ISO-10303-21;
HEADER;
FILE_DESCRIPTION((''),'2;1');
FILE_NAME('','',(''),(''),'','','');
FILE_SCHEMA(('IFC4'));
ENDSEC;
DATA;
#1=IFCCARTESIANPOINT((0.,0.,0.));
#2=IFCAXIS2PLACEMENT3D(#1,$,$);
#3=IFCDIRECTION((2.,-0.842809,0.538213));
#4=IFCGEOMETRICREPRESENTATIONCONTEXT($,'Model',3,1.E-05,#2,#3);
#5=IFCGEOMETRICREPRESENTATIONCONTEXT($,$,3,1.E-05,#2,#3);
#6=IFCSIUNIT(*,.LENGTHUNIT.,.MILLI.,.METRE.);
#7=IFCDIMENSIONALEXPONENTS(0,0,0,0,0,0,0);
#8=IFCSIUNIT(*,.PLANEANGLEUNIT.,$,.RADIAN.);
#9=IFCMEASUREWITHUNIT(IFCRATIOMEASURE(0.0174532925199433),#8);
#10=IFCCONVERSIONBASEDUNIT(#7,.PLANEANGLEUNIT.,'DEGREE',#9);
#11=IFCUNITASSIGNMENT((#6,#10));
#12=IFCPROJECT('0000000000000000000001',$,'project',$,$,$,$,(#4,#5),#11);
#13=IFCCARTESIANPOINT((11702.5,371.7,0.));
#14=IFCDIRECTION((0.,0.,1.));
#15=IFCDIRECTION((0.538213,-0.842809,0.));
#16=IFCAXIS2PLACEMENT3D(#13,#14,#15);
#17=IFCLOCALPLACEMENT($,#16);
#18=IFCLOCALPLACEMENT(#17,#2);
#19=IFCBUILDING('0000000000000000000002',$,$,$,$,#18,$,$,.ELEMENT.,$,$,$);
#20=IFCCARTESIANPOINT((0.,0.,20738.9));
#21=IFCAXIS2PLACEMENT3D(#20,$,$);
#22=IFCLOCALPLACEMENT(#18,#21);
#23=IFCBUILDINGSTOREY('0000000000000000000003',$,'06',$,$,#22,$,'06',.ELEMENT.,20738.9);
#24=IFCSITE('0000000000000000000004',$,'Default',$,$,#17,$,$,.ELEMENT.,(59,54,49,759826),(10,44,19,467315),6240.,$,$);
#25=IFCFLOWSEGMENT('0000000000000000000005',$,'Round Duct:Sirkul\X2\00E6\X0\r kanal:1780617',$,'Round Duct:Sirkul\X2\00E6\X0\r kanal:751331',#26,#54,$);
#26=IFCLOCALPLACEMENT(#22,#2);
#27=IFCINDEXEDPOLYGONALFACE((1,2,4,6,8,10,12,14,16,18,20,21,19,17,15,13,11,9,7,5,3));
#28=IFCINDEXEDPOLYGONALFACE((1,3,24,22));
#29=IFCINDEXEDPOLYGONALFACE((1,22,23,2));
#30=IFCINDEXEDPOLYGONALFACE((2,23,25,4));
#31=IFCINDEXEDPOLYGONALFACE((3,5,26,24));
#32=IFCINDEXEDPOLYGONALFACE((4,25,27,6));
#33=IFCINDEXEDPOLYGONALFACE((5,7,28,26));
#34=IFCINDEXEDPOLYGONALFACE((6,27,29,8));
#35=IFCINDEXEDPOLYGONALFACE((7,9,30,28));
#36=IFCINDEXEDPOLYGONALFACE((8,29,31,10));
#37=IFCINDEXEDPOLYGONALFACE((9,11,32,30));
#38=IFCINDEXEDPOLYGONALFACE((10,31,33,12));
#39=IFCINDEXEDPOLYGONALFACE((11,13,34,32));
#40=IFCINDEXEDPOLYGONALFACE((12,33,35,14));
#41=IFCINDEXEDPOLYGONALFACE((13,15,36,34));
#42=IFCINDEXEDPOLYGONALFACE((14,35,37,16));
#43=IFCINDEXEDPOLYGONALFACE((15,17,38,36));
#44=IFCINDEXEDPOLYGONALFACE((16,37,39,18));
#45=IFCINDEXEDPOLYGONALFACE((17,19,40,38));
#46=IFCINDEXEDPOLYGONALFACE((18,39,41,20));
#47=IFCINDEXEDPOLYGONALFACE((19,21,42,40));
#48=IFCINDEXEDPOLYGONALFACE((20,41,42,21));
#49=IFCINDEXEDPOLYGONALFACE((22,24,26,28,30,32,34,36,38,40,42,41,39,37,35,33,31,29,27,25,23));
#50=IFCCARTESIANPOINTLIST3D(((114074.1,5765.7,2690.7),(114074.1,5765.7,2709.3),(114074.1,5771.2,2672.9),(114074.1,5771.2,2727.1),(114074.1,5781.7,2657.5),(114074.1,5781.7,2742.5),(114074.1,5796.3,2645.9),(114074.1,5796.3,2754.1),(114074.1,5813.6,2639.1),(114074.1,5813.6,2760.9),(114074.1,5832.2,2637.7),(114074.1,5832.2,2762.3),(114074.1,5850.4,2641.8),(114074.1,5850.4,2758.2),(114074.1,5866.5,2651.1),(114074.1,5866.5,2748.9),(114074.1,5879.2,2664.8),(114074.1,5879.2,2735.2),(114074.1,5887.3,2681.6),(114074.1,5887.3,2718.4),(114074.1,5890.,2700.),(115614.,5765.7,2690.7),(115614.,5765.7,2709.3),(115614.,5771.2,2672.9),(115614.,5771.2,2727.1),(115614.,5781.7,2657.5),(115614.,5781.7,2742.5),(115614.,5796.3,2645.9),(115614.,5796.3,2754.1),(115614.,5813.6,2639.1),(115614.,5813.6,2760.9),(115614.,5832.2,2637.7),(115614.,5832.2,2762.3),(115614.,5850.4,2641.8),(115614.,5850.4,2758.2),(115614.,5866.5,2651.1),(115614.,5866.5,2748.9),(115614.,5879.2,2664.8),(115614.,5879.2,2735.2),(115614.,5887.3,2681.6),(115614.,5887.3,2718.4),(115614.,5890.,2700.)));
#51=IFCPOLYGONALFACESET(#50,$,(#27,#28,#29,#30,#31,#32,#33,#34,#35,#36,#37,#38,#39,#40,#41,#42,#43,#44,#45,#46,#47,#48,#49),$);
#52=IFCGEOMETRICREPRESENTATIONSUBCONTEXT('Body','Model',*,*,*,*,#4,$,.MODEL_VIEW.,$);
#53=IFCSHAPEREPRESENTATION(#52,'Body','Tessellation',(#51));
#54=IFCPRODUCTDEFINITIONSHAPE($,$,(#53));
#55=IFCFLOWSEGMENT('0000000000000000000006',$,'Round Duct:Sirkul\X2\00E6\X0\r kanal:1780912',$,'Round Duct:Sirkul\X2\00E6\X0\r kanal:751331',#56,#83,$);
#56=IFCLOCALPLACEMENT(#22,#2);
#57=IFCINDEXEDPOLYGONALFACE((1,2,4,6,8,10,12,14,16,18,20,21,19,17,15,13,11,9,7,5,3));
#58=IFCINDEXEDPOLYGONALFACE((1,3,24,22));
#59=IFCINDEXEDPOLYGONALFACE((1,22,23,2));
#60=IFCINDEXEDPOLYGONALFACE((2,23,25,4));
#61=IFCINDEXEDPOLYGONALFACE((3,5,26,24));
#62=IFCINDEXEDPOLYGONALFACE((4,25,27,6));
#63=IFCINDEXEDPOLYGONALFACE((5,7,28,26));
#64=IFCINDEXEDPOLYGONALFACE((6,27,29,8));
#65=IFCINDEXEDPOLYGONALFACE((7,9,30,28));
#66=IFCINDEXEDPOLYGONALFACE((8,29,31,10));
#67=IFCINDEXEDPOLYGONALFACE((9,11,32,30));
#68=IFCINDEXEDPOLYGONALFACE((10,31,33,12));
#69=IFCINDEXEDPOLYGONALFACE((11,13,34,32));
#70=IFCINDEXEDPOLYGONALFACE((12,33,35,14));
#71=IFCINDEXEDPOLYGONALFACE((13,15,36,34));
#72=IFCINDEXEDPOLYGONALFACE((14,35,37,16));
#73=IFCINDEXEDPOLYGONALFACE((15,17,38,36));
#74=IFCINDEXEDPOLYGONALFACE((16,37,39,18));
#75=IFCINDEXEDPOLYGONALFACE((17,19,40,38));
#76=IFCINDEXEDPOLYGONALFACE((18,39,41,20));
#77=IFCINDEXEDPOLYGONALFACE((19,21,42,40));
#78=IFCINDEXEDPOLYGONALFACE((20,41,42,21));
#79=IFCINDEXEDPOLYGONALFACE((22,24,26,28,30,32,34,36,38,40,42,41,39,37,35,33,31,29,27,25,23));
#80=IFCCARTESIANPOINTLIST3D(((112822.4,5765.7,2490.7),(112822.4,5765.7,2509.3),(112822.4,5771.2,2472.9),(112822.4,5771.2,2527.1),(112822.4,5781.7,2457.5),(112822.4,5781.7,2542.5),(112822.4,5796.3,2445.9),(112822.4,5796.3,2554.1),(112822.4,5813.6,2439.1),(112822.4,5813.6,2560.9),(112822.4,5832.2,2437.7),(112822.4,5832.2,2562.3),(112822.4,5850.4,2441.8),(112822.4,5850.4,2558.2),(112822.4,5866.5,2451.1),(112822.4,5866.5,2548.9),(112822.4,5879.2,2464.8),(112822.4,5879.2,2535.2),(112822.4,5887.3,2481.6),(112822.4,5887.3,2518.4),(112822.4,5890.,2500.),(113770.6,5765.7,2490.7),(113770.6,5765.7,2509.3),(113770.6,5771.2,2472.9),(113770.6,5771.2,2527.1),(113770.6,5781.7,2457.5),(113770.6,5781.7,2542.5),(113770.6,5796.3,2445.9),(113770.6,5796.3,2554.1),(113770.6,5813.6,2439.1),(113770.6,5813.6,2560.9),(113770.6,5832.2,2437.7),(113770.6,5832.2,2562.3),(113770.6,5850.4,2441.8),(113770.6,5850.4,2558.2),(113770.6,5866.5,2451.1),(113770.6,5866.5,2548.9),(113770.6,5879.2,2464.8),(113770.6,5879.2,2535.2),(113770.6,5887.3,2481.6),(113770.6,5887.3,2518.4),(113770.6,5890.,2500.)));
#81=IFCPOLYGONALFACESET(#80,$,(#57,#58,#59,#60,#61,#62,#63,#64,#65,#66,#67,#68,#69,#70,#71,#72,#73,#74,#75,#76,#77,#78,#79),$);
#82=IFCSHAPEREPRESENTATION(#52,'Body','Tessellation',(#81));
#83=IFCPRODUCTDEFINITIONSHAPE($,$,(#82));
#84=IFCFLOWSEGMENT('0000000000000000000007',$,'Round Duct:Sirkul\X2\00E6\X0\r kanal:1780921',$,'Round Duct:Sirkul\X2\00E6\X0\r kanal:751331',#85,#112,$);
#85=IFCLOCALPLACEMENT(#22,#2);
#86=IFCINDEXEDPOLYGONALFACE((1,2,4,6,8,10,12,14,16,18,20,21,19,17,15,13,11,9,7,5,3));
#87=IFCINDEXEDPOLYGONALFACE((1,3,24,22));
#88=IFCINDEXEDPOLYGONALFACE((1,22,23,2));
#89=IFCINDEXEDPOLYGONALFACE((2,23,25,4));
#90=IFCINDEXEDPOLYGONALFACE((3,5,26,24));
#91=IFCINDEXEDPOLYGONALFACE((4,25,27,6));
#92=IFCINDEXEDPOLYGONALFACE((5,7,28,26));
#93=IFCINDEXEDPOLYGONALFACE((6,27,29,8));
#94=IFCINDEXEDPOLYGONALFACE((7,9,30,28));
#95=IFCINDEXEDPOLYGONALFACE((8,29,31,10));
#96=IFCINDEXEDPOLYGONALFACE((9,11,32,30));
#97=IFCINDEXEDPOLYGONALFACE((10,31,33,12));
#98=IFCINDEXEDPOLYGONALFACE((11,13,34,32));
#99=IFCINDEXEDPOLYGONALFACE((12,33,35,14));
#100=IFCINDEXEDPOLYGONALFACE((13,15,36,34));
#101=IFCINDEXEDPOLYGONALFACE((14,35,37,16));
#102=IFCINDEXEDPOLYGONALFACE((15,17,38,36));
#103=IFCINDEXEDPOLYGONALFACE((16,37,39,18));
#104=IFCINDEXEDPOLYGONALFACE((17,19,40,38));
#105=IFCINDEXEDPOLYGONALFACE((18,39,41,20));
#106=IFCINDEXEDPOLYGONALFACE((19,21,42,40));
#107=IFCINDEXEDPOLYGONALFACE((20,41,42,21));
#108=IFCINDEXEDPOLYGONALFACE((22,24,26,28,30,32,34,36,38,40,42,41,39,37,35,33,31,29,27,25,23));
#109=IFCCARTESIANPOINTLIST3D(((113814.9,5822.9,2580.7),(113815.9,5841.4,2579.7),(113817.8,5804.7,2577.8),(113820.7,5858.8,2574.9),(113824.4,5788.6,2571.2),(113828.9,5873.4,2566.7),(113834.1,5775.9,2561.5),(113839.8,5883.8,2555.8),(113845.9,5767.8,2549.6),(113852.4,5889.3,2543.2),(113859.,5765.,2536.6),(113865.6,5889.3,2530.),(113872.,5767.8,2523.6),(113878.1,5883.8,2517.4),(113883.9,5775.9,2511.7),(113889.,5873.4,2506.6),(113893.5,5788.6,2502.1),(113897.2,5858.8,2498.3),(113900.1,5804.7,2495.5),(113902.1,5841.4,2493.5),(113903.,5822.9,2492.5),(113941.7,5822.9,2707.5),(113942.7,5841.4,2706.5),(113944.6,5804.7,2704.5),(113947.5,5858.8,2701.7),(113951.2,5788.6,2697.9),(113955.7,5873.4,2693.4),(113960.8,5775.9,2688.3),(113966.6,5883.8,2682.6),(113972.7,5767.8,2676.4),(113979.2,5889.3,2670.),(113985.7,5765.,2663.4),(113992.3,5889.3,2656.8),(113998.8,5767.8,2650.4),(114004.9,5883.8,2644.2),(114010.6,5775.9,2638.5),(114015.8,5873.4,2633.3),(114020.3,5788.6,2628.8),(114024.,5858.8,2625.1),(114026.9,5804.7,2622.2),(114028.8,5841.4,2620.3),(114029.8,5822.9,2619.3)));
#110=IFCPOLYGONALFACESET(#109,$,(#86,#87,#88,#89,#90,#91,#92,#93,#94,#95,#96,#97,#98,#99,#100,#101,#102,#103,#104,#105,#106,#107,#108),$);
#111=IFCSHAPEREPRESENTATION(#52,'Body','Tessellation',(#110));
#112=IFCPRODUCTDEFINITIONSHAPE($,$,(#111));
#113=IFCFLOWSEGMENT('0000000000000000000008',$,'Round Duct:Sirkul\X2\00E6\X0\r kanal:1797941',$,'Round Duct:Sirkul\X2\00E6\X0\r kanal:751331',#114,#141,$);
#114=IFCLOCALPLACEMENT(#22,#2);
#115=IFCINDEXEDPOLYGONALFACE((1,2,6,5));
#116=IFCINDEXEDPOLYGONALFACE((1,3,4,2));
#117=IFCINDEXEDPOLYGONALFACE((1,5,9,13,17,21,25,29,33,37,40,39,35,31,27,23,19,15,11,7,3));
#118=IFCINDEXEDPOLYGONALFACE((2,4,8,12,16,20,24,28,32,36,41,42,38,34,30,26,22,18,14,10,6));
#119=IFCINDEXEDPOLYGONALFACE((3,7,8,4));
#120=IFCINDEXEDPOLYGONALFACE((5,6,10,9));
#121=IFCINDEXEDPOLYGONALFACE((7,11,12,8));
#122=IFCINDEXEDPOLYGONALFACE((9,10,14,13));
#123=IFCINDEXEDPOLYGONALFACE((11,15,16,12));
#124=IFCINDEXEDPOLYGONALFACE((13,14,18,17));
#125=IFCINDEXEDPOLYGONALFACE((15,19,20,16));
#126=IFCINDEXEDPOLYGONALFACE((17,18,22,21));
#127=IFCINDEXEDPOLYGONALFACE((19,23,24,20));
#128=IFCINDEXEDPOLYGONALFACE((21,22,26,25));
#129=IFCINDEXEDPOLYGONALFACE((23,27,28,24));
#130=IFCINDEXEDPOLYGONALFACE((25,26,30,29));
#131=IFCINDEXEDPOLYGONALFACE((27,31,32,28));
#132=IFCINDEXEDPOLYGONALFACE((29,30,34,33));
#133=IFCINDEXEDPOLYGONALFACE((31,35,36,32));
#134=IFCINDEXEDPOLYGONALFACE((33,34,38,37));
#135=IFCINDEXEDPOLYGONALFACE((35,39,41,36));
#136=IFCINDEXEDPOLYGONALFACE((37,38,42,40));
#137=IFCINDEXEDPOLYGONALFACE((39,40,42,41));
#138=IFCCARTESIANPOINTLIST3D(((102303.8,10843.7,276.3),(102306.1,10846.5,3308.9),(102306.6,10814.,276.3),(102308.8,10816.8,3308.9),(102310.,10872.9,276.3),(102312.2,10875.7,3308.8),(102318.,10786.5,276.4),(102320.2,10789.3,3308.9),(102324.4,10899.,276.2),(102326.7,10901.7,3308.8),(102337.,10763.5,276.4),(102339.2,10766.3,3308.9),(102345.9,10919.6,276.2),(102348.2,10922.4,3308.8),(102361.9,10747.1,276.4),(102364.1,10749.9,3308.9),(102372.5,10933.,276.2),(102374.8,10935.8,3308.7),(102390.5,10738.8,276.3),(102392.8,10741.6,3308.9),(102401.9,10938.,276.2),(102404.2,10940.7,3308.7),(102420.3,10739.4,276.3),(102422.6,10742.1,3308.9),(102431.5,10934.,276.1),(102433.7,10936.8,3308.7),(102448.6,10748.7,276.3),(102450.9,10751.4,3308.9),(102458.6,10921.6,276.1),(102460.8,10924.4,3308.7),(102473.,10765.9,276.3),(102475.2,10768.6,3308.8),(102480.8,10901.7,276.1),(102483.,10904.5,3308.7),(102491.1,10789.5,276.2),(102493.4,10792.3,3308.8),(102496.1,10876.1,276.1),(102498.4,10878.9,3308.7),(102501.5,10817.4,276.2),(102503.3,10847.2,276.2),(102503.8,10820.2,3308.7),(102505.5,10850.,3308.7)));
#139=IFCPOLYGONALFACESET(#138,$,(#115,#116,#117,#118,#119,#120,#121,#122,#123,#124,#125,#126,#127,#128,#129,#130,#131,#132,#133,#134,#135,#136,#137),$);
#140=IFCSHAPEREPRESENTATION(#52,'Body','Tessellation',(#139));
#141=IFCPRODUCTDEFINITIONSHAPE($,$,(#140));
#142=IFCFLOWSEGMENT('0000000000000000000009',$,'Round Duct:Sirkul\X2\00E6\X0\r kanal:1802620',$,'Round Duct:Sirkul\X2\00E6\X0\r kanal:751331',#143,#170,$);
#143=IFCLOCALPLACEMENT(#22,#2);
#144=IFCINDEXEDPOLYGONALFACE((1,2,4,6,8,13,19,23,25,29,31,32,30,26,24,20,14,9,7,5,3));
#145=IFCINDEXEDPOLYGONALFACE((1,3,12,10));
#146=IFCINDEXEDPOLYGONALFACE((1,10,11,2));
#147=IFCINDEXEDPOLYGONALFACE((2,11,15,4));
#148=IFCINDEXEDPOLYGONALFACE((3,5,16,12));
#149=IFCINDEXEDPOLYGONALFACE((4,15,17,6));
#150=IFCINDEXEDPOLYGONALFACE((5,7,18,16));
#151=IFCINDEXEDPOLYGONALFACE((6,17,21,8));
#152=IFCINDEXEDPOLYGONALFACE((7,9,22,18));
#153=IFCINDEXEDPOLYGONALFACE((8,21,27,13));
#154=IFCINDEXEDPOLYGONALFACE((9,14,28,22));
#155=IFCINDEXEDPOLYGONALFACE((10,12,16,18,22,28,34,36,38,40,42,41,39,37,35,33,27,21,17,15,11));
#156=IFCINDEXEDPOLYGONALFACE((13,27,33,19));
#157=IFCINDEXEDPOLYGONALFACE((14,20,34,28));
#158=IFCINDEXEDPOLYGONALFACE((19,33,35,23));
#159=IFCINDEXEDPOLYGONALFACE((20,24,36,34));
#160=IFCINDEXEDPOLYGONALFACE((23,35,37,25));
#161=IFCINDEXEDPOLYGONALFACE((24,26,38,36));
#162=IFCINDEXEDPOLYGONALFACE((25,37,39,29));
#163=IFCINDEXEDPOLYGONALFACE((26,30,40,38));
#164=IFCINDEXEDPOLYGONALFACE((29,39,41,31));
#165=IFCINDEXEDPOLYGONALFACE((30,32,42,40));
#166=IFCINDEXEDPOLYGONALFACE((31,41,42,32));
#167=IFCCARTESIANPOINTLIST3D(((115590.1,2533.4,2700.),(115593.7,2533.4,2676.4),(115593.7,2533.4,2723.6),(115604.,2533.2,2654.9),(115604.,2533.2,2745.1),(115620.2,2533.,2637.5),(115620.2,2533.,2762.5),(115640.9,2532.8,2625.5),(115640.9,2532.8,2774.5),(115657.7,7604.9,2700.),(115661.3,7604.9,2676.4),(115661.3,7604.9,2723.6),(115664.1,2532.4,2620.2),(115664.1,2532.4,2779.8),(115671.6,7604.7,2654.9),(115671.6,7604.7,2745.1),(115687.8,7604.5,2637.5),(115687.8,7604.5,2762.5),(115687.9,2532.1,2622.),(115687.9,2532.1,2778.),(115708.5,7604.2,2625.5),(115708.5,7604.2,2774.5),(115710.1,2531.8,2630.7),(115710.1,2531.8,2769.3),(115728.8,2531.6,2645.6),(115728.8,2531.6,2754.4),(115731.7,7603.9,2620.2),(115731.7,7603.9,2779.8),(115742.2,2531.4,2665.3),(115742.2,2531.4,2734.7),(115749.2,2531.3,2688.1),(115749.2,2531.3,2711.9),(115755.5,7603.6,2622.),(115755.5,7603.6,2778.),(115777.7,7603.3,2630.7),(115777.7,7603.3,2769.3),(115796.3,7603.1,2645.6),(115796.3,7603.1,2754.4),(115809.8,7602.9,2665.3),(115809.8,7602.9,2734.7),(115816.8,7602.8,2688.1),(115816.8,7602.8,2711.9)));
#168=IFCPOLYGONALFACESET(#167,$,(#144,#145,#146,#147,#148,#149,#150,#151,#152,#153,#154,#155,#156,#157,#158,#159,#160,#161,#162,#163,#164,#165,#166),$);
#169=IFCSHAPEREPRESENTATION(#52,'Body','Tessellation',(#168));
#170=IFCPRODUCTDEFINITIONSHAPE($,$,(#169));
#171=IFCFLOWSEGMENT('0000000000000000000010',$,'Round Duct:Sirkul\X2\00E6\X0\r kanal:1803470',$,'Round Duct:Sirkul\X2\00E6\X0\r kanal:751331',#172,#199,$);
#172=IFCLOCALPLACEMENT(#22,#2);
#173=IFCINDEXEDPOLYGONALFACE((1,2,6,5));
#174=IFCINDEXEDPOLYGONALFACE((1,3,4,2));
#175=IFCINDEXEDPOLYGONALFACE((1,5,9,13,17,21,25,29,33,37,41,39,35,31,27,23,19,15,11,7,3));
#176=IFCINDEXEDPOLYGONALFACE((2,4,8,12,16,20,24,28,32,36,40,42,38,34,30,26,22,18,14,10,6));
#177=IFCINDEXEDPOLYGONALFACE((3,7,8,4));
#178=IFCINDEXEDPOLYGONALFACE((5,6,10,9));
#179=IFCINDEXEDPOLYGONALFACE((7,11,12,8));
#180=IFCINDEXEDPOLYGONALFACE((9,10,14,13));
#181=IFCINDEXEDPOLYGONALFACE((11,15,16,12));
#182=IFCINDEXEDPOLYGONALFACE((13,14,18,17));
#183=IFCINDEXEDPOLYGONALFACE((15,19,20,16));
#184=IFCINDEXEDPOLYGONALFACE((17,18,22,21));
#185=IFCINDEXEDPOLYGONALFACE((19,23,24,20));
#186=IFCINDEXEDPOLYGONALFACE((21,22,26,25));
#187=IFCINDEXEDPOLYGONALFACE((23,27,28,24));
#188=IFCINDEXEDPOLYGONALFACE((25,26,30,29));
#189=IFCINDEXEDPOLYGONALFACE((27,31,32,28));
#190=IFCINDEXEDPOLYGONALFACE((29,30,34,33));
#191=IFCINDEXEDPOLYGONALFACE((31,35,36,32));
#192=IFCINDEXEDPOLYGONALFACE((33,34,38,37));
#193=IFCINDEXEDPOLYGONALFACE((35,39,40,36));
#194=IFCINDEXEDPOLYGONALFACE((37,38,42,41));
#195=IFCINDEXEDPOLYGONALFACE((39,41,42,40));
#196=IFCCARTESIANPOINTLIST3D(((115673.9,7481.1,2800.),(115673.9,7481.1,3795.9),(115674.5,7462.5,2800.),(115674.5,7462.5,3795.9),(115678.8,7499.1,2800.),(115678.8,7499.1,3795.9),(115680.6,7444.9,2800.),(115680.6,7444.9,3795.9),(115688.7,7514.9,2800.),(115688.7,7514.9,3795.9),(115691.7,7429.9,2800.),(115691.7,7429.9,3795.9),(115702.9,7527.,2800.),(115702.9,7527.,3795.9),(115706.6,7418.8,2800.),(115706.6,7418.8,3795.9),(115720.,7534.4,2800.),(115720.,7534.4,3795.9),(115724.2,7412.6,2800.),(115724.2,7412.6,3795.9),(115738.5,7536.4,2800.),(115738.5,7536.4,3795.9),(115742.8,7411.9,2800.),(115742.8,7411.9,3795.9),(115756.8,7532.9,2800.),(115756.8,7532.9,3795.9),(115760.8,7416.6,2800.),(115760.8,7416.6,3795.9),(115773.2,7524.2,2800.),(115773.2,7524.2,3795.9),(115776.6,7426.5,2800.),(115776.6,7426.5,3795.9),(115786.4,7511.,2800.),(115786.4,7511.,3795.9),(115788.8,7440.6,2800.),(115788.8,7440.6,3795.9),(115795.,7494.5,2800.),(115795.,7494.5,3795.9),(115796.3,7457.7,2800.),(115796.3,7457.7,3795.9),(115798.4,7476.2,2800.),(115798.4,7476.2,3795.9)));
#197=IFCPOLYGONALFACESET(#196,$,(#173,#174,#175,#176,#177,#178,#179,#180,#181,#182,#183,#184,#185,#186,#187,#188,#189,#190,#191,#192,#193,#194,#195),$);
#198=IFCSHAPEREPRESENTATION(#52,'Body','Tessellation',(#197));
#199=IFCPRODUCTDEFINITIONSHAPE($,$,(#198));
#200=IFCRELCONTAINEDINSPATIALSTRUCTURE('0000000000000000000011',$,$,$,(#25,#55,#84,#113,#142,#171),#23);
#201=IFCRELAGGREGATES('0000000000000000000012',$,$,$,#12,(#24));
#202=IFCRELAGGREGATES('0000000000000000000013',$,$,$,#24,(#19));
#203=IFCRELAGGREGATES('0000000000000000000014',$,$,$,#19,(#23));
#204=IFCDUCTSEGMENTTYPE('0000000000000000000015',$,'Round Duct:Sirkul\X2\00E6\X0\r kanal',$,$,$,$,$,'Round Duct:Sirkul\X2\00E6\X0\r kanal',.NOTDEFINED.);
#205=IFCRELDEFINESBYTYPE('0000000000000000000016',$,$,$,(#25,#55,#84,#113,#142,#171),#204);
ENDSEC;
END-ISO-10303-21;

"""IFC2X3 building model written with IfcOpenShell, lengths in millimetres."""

from ifc_helpers import new_model, entity, si_unit, converted_unit, direction, frame, frame_2d, origin, origin_2d_with_axis, place, context, subcontext, project, spatial, circle, extrude, type_object, element, save


model = new_model("IFC2X3")

# Units and contexts
model_context = context("Model", 3, precision=1e-05, world=origin(), true_north=direction((2.0, -0.842809, 0.538213)))
context_of_model = context(None, 3, precision=1e-05, world=origin(), true_north=direction((2.0, -0.842809, 0.538213)))
body_context = subcontext(model_context, "Body", "Model", "MODEL_VIEW")
ifc_project = project(units=[si_unit("LENGTHUNIT", "METRE", prefix="MILLI"), converted_unit("PLANEANGLEUNIT", "DEGREE", entity("IfcRatioMeasure", 0.0174532925199433), si_unit("PLANEANGLEUNIT", "RADIAN"), dimensions=[0, 0, 0, 0, 0, 0, 0])], contexts=[model_context, context_of_model])

# Site, building, storey
site_placement = place(None, frame((11702.5, 371.7, 0.0), z_axis=(0.0, 0.0, 1.0), x_axis=(0.538213, -0.842809, 0.0)))
site = spatial("IfcSite", under=ifc_project, at=site_placement, Name="Default", CompositionType="ELEMENT", RefLatitude=(59, 54, 49, 759826), RefLongitude=(10, 44, 19, 467315), RefElevation=6240.0)
building_placement = place(site_placement, origin())
building = spatial("IfcBuilding", under=site, at=building_placement, CompositionType="ELEMENT")
storey_placement = place(building_placement, frame((0.0, 0.0, 20738.9)))
storey = spatial("IfcBuildingStorey", under=building, at=storey_placement, Name="06", LongName="06", CompositionType="ELEMENT", Elevation=20738.9)

# Flow segments
duct_segment_type = type_object("IfcDuctSegmentType", Name="Round Duct:Sirkulær kanal", ElementType="Round Duct:Sirkulær kanal", PredefinedType="NOTDEFINED")
flow_segment_1_placement = place(storey_placement, origin())
element("IfcFlowSegment", 1, at=flow_segment_1_placement, inside=storey, type_object=duct_segment_type, Name="Round Duct:Sirkulær kanal:1780617", ObjectType="Round Duct:Sirkulær kanal:751331", context=body_context, shape_type="SweptSolid", body=[
    extrude(circle(Radius=62.5, at=frame_2d((0.0, 0.0), x_axis=(1.0, 0.0))), frame((114074.1, 5827.5, 2700.0), z_axis=(1.0, 0.0, 0.0), x_axis=(0.0, 1.0, 0.0)), (0.0, 0.0, 1.0), 1539.9),
])
flow_segment_2_placement = place(storey_placement, origin())
element("IfcFlowSegment", 2, at=flow_segment_2_placement, inside=storey, type_object=duct_segment_type, Name="Round Duct:Sirkulær kanal:1780912", ObjectType="Round Duct:Sirkulær kanal:751331", context=body_context, shape_type="SweptSolid", body=[
    extrude(circle(Radius=62.5, at=frame_2d((0.0, 0.0), x_axis=(1.0, 0.0))), frame((112822.4, 5827.5, 2500.0), z_axis=(1.0, 0.0, 0.0), x_axis=(0.0, 1.0, 0.0)), (0.0, 0.0, 1.0), 948.2),
])
flow_segment_3_placement = place(storey_placement, origin())
element("IfcFlowSegment", 3, at=flow_segment_3_placement, inside=storey, type_object=duct_segment_type, Name="Round Duct:Sirkulær kanal:1780921", ObjectType="Round Duct:Sirkulær kanal:751331", context=body_context, shape_type="SweptSolid", body=[
    extrude(circle(Radius=62.5, at=frame_2d((0.0, 0.0), x_axis=(1.0, 0.0))), frame((113859.0, 5827.5, 2536.6), z_axis=(0.707107, 0.0, 0.707107), x_axis=(0.0, -1.0, 0.0)), (0.0, 0.0, 1.0), 179.3),
])
flow_segment_4_placement = place(storey_placement, origin())
element("IfcFlowSegment", 4, at=flow_segment_4_placement, inside=storey, type_object=duct_segment_type, Name="Round Duct:Sirkulær kanal:1797941", ObjectType="Round Duct:Sirkulær kanal:751331", context=body_context, shape_type="SweptSolid", body=[
    extrude(circle(Radius=100.0, at=origin_2d_with_axis()), frame((102403.7, 10838.0, 276.2), z_axis=(0.000742, 0.000917, 0.999999), x_axis=(-0.857167, -0.515038, 0.001109)), (0.0, 0.0, 1.0), 3032.6),
])
flow_segment_5_placement = place(storey_placement, origin())
element("IfcFlowSegment", 5, at=flow_segment_5_placement, inside=storey, type_object=duct_segment_type, Name="Round Duct:Sirkulær kanal:1802620", ObjectType="Round Duct:Sirkulær kanal:751331", context=body_context, shape_type="SweptSolid", body=[
    extrude(circle(Radius=80.0, at=origin_2d_with_axis()), frame((115670.1, 2532.4, 2700.0), z_axis=(0.013327, 0.999911, 0.0), x_axis=(-0.999911, 0.013327, 0.0)), (0.0, 0.0, 1.0), 5071.9),
])
flow_segment_6_placement = place(storey_placement, origin())
element("IfcFlowSegment", 6, at=flow_segment_6_placement, inside=storey, type_object=duct_segment_type, Name="Round Duct:Sirkulær kanal:1803470", ObjectType="Round Duct:Sirkulær kanal:751331", context=body_context, shape_type="SweptSolid", body=[
    extrude(circle(Radius=62.5, at=frame_2d((0.0, 0.0), x_axis=(1.0, 0.0))), frame((115736.0, 7474.0, 2800.0), z_axis=(0.0, 0.0, 1.0), x_axis=(0.999391, 0.034899, 0.0)), (0.0, 0.0, 1.0), 995.9),
])

save(model, "model.ifc")
